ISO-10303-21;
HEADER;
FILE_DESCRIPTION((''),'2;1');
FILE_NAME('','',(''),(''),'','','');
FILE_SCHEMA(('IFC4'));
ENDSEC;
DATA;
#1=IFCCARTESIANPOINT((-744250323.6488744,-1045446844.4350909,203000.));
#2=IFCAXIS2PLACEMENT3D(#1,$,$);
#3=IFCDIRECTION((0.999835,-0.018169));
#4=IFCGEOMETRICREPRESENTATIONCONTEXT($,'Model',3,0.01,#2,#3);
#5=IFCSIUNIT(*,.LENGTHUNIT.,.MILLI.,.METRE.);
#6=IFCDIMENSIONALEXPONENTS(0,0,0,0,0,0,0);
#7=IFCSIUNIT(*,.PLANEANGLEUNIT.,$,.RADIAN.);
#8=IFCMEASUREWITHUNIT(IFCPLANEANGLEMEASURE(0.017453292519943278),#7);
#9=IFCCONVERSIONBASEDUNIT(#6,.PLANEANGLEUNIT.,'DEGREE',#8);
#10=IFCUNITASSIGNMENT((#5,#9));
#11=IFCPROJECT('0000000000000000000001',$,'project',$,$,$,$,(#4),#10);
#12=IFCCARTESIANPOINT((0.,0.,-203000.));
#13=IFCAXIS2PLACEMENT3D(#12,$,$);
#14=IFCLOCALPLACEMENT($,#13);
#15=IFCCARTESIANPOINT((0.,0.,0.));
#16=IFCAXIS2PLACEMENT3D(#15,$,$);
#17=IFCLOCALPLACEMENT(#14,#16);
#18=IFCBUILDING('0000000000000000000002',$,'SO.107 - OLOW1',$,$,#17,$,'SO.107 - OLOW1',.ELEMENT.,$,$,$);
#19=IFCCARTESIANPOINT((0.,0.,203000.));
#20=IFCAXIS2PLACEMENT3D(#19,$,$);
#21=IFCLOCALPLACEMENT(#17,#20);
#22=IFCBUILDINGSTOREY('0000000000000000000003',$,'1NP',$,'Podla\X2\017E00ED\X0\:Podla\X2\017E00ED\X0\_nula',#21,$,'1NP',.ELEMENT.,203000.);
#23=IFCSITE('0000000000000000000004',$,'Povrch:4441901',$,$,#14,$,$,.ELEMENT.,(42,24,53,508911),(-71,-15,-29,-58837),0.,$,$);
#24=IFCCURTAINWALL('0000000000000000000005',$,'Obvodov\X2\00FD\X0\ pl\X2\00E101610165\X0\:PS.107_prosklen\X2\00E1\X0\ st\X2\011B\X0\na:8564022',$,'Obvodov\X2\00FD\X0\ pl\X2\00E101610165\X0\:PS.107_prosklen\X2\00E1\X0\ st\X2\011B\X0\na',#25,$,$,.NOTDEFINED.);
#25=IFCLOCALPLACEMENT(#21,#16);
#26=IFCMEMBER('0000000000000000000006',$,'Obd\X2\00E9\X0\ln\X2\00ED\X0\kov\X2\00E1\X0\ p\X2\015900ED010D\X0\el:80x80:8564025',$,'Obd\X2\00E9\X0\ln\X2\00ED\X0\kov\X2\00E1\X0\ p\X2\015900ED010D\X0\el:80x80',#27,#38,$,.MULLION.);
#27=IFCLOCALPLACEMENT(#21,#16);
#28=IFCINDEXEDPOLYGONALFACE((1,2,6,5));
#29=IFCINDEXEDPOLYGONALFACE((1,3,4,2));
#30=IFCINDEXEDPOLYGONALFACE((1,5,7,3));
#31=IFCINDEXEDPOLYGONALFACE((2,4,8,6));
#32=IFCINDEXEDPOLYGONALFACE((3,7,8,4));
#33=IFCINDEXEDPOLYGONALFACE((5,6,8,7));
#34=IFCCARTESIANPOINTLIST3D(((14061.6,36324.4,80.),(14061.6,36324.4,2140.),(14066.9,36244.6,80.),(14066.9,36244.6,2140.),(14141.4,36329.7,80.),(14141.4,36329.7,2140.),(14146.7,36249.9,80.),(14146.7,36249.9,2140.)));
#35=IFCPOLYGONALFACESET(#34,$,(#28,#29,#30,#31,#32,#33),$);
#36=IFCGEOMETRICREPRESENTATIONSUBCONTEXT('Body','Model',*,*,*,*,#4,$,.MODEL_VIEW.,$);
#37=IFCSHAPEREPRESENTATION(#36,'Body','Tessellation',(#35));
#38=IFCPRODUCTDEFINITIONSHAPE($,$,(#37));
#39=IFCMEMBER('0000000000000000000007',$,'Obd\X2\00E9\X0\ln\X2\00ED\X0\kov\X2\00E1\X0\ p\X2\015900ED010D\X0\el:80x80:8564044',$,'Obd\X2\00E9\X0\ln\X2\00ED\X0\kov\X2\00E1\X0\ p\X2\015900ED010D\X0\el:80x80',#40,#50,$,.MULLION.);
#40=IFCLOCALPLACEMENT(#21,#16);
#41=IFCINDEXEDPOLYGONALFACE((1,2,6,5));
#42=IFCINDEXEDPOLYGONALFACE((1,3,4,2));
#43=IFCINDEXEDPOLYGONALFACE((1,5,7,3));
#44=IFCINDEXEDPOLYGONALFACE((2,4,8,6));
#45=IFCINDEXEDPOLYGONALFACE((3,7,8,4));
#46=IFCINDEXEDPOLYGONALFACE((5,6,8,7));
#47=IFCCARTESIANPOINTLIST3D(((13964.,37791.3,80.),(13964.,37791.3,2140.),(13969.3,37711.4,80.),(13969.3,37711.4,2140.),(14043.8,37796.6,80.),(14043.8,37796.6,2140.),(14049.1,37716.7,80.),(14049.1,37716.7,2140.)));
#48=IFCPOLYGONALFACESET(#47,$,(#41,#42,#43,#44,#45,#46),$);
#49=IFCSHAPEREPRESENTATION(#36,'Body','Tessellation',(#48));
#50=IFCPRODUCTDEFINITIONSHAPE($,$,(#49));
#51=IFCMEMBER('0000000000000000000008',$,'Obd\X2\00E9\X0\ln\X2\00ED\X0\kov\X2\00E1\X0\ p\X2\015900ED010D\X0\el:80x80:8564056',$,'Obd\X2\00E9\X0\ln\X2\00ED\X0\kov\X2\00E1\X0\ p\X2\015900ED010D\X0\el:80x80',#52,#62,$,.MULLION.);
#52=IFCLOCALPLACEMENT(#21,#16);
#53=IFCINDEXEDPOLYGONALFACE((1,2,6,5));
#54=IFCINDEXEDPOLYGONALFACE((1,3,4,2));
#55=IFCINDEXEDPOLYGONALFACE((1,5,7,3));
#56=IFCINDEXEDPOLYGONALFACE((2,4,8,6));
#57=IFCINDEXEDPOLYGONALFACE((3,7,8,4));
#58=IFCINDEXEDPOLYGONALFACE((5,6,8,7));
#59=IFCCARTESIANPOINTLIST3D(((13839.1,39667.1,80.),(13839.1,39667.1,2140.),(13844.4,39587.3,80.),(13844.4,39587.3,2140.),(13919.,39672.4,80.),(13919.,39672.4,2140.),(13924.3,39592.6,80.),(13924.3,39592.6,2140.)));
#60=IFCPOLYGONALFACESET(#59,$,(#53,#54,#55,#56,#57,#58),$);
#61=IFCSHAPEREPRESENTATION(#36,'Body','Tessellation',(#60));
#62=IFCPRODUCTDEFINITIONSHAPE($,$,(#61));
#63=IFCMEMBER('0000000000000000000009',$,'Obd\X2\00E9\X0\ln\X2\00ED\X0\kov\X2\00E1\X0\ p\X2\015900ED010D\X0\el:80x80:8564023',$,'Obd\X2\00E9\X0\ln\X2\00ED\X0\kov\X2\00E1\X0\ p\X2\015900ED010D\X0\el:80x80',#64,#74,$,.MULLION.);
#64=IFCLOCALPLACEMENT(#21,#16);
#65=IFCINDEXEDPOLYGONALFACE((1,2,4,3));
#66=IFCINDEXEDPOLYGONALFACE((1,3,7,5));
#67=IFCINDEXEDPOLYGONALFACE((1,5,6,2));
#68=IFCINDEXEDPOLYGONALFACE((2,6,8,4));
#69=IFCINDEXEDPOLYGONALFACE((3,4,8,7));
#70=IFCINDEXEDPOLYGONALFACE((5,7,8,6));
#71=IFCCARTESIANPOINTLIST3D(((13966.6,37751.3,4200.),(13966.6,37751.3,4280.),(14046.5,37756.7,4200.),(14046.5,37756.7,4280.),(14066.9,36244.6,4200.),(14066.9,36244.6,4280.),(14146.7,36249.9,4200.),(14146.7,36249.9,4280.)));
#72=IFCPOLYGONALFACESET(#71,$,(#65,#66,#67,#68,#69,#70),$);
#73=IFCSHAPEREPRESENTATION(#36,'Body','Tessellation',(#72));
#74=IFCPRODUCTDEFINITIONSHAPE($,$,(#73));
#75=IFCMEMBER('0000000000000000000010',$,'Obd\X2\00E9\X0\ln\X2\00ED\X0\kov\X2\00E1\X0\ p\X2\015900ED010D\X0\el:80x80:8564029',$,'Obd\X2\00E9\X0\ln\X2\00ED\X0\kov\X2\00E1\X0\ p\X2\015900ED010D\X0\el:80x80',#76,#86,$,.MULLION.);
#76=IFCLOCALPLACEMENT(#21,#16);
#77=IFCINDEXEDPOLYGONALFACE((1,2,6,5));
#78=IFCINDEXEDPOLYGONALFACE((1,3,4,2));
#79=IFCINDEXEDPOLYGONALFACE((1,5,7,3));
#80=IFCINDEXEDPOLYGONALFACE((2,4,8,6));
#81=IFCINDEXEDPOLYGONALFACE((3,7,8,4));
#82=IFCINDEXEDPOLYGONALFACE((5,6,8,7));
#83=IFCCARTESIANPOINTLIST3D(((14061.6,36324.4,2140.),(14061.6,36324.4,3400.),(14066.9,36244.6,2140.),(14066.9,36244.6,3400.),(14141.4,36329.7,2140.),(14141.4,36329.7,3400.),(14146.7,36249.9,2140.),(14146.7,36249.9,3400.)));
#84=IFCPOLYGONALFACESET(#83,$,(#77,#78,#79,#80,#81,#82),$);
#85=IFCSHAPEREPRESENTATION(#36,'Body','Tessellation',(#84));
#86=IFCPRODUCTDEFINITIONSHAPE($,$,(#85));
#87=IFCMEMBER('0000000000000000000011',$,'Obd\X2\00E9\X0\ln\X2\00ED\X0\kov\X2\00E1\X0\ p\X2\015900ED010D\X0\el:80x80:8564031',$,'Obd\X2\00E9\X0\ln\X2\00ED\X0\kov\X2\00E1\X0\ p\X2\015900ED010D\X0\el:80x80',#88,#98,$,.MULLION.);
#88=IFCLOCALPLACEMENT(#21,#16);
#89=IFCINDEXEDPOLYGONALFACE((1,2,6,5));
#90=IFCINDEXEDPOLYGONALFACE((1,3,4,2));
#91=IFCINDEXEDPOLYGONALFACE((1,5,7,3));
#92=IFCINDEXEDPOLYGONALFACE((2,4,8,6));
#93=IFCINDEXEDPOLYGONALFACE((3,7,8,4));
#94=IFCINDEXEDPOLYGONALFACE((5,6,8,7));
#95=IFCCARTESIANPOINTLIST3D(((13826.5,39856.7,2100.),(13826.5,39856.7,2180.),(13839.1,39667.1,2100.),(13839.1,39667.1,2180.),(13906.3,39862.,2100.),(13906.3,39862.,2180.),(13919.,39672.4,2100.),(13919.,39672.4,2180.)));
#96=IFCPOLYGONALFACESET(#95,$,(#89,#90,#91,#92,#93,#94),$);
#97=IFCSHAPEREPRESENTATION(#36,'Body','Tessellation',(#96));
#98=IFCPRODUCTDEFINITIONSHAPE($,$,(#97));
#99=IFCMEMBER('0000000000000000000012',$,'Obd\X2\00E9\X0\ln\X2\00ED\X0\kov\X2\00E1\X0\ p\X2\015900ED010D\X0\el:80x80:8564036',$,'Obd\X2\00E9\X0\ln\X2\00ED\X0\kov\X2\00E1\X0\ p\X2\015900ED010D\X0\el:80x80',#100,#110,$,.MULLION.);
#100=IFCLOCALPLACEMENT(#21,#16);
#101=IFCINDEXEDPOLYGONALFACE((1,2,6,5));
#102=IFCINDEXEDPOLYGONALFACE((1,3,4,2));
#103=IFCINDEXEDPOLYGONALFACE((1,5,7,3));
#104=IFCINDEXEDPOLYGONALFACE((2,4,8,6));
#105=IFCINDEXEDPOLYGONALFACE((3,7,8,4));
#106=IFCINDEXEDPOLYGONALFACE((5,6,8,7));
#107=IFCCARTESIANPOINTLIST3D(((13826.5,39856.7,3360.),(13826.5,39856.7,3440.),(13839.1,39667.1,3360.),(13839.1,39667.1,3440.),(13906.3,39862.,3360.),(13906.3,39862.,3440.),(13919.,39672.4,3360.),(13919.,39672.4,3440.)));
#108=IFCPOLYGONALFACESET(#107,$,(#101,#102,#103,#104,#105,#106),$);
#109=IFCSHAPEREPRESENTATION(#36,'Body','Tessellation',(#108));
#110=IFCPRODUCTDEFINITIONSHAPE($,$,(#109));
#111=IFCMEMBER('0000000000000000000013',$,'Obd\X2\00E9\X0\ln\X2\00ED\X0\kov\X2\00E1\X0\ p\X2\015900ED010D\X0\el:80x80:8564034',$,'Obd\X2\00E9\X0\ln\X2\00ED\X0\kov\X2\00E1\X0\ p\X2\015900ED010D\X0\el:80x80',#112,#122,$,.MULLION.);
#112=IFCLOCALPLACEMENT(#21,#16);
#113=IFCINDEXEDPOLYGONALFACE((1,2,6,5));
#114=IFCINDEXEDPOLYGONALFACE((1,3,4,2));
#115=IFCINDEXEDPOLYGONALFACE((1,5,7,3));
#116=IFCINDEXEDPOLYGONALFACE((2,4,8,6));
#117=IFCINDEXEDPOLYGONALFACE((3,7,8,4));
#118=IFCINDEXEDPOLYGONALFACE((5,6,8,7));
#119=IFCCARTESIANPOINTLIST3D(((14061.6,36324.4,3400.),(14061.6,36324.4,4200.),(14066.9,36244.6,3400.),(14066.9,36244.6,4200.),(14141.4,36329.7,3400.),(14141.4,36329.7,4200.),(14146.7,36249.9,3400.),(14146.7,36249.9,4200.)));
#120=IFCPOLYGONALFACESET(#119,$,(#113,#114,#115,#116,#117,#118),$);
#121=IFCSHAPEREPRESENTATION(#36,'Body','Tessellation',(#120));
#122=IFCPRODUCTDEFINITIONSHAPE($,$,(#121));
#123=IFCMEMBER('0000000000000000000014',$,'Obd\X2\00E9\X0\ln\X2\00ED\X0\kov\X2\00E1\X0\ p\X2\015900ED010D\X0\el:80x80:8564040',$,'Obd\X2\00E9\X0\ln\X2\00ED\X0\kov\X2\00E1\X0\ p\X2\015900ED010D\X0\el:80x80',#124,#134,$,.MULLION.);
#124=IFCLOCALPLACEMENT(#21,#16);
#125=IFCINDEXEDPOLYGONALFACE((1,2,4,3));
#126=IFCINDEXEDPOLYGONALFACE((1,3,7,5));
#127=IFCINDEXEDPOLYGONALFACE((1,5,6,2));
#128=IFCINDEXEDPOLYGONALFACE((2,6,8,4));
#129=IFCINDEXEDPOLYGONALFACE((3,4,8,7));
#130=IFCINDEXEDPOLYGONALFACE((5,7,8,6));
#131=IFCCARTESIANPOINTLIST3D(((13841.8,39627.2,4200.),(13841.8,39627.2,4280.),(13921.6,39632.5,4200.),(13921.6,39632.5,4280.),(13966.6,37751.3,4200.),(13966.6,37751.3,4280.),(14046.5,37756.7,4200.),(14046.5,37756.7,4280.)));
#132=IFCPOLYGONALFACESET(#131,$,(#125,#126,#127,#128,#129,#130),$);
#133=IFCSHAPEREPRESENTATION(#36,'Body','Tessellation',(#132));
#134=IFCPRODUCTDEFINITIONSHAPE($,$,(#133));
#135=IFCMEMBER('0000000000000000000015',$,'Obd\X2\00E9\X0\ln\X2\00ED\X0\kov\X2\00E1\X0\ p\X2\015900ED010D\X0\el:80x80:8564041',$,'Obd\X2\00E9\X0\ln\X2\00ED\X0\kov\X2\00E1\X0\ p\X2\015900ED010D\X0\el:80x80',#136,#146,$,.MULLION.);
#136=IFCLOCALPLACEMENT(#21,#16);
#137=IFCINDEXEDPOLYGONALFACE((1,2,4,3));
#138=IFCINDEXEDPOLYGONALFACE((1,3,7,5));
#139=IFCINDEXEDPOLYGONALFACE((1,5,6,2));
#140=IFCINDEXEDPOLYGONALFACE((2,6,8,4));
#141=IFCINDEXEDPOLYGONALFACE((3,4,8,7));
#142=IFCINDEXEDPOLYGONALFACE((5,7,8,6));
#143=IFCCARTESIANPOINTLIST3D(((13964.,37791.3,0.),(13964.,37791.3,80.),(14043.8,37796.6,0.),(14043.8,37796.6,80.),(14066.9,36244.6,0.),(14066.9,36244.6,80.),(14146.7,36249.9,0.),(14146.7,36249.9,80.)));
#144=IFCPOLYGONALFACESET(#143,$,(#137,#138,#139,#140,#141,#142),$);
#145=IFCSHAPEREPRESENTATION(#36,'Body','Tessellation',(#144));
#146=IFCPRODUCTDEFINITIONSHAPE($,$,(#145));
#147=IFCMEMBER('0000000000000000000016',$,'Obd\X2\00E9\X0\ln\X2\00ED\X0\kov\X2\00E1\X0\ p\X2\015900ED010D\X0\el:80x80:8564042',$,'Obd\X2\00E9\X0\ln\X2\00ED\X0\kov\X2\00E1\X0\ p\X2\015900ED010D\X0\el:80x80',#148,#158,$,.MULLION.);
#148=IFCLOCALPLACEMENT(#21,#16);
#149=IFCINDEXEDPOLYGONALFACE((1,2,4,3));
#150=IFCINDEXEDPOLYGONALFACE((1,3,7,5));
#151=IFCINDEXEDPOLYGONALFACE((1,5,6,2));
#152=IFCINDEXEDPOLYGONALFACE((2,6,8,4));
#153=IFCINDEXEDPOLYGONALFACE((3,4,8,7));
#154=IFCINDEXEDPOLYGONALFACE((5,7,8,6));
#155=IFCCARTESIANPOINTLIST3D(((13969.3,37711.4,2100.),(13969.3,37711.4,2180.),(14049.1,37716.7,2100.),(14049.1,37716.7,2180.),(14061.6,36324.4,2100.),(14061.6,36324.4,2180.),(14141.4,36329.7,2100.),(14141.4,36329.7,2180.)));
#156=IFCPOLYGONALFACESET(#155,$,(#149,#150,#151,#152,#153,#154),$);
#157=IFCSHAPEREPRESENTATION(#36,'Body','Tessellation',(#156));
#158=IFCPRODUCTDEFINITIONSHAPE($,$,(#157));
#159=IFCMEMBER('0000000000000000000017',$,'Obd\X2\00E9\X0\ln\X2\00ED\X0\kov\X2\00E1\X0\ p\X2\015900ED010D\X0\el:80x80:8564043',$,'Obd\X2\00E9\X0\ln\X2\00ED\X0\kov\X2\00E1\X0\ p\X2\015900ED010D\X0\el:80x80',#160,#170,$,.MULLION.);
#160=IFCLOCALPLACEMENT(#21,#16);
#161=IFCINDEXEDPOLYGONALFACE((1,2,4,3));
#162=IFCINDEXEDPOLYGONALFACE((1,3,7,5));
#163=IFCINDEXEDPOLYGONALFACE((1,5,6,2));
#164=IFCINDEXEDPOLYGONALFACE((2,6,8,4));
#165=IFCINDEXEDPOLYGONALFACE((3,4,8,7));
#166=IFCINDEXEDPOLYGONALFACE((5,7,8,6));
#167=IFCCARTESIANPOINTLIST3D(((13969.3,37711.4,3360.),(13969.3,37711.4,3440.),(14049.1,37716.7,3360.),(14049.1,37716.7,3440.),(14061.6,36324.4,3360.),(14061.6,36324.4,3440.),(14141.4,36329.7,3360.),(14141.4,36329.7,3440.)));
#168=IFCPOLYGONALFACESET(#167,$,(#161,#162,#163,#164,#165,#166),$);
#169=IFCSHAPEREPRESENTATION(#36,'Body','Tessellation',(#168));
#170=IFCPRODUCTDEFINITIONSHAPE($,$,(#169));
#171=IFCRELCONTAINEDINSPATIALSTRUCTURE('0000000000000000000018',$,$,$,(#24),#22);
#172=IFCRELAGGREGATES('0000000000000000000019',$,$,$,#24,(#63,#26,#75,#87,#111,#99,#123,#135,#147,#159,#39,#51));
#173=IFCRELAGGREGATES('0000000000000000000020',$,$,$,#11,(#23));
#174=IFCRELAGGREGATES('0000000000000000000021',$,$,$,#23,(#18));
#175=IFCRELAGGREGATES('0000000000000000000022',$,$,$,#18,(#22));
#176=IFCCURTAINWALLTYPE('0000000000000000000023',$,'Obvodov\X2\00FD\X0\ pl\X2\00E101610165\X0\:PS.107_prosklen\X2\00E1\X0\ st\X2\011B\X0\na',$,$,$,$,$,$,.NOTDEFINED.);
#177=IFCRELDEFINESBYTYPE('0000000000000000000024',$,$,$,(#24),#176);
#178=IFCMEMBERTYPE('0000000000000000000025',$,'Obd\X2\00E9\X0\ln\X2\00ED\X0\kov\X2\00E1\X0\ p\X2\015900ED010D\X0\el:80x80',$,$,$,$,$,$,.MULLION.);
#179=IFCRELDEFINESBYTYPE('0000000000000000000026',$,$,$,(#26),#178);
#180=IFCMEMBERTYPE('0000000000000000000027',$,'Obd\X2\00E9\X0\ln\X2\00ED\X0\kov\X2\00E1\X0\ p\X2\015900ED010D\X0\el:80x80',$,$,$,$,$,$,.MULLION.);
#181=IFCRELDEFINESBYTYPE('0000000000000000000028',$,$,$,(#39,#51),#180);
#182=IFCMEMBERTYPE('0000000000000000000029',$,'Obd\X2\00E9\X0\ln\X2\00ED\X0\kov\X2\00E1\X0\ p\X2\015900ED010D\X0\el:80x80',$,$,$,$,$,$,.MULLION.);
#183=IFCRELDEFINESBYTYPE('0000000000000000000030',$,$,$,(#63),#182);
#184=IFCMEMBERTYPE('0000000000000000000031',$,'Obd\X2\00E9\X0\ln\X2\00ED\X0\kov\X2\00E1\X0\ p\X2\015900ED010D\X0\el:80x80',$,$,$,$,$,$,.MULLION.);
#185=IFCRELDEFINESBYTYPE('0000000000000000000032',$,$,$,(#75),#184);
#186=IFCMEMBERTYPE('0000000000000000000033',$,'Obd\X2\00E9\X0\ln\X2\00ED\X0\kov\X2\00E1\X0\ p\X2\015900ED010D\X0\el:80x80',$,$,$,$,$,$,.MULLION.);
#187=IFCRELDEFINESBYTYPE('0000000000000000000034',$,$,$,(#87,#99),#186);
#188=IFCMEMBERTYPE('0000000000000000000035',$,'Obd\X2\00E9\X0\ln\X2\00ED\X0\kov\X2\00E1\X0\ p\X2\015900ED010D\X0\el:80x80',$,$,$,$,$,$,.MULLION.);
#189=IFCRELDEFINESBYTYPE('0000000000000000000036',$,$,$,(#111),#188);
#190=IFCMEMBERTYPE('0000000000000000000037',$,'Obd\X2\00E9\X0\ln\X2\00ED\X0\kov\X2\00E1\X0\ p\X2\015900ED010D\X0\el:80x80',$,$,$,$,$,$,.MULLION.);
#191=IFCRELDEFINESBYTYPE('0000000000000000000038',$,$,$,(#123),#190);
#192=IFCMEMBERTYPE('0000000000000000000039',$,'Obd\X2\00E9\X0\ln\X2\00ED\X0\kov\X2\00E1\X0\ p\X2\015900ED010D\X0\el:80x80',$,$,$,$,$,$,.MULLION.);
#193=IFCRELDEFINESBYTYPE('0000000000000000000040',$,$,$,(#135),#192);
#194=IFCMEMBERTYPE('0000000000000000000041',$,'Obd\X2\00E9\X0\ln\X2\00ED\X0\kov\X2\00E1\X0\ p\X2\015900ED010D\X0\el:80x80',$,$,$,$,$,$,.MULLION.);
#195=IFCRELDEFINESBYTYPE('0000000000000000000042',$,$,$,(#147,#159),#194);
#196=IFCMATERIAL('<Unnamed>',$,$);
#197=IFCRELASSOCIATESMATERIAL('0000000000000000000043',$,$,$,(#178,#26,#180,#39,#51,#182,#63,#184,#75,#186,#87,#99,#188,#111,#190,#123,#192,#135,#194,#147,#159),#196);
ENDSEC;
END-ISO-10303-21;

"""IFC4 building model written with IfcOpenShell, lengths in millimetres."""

from ifc_helpers import new_model, entity, si_unit, converted_unit, direction, frame, origin, place, context, subcontext, project, spatial, indexed_curve, outline, extrude, source, transform, mapped, material, type_object, type_shapes, element, aggregate, save


model = new_model("IFC4")

# Units and contexts
model_context = context("Model", 3, precision=0.01, world=frame((-744250323.6488744, -1045446844.4350909, 203000.0)), true_north=direction((0.999835, -0.018169)))
body_context = subcontext(model_context, "Body", "Model", "MODEL_VIEW")
ifc_project = project(units=[si_unit("LENGTHUNIT", "METRE", prefix="MILLI"), converted_unit("PLANEANGLEUNIT", "DEGREE", entity("IfcPlaneAngleMeasure", 0.017453292519943278), si_unit("PLANEANGLEUNIT", "RADIAN"), dimensions=[0, 0, 0, 0, 0, 0, 0])], contexts=[model_context])

# Site, building, storey
site_placement = place(None, frame((0.0, 0.0, -203000.0)))
site = spatial("IfcSite", under=ifc_project, at=site_placement, Name="Povrch:4441901", CompositionType="ELEMENT", RefLatitude=(42, 24, 53, 508911), RefLongitude=(-71, -15, -29, -58837), RefElevation=0.0)
building_placement = place(site_placement, origin())
building = spatial("IfcBuilding", under=site, at=building_placement, Name="SO.107 - OLOW1", LongName="SO.107 - OLOW1", CompositionType="ELEMENT")
storey_placement = place(building_placement, frame((0.0, 0.0, 203000.0)))
storey = spatial("IfcBuildingStorey", under=building, at=storey_placement, Name="1NP", ObjectType="Podlaží:Podlaží_nula", LongName="1NP", CompositionType="ELEMENT", Elevation=203000.0)

# Curtain wall, members
curtain_wall_type = type_object("IfcCurtainWallType", Name="Obvodový plášť:PS.107_prosklená stěna", PredefinedType="NOTDEFINED")
curtain_wall_placement = place(storey_placement, frame((0.0, 0.0, -203000.0)))
curtain_wall = element("IfcCurtainWall", 1, at=curtain_wall_placement, inside=storey, type_object=curtain_wall_type, Name="Obvodový plášť:PS.107_prosklená stěna:8564022", ObjectType="Obvodový plášť:PS.107_prosklená stěna", PredefinedType="NOTDEFINED")
ifc_material_1 = material(Name="<Unnamed>")
member_type_1 = type_object("IfcMemberType", Name="Obdélníková příčel:80x80", PredefinedType="MULLION", material=ifc_material_1)
shared_shape_1 = source(origin(), body_context, "Body", "SweptSolid", [
    extrude(outline(indexed_curve([(-40.0, -40.0), (40.0, -40.0), (40.0, 40.0), (-40.0, 40.0), (-40.0, -40.0)], self_intersect=False)), frame((-40.0, 0.0, -2060.0), z_axis=(0.0, 0.0, 1.0), x_axis=(-1.0, 0.0, 0.0)), (0.0, 0.0, 1.0), 2060.0),
])
type_shapes(member_type_1, [shared_shape_1])
member_1_placement = place(curtain_wall_placement, frame((14106.8, 36247.3, 203080.0), z_axis=(0.0, 0.0, -1.0), x_axis=(0.066409, -0.997792, 0.0)))
member_1 = element("IfcMember", 2, at=member_1_placement, type_object=member_type_1, material=ifc_material_1, Name="Obdélníková příčel:80x80:8564025", ObjectType="Obdélníková příčel:80x80", PredefinedType="MULLION", context=body_context, shape_type="MappedRepresentation", body=[
    mapped(shared_shape_1, transform((0.0, 0.0, 0.0), scale=1.0)),
])
member_type_2 = type_object("IfcMemberType", Name="Obdélníková příčel:80x80", PredefinedType="MULLION", material=ifc_material_1)
shared_shape_2 = source(origin(), body_context, "Body", "SweptSolid", [
    extrude(outline(indexed_curve([(-40.0, -40.0), (40.0, -40.0), (40.0, 40.0), (-40.0, 40.0), (-40.0, -40.0)], self_intersect=False)), frame((0.0, 0.0, -2060.0), z_axis=(0.0, 0.0, 1.0), x_axis=(-1.0, 0.0, 0.0)), (0.0, 0.0, 1.0), 2060.0),
])
type_shapes(member_type_2, [shared_shape_2])
member_2_placement = place(curtain_wall_placement, frame((14006.5, 37754.0, 203080.0), z_axis=(0.0, 0.0, -1.0), x_axis=(0.066409, -0.997792, 0.0)))
member_2 = element("IfcMember", 3, at=member_2_placement, type_object=member_type_2, material=ifc_material_1, Name="Obdélníková příčel:80x80:8564044", ObjectType="Obdélníková příčel:80x80", PredefinedType="MULLION", context=body_context, shape_type="MappedRepresentation", body=[
    mapped(shared_shape_2, transform((0.0, 0.0, 0.0), scale=1.0)),
])
member_3_placement = place(curtain_wall_placement, frame((13881.7, 39629.8, 203080.0), z_axis=(0.0, 0.0, -1.0), x_axis=(0.066409, -0.997792, 0.0)))
member_3 = element("IfcMember", 4, at=member_3_placement, type_object=member_type_2, material=ifc_material_1, Name="Obdélníková příčel:80x80:8564056", ObjectType="Obdélníková příčel:80x80", PredefinedType="MULLION", context=body_context, shape_type="MappedRepresentation", body=[
    mapped(shared_shape_2, transform((0.0, 0.0, 0.0), scale=1.0)),
])
member_type_3 = type_object("IfcMemberType", Name="Obdélníková příčel:80x80", PredefinedType="MULLION", material=ifc_material_1)
shared_shape_3 = source(origin(), body_context, "Body", "SweptSolid", [
    extrude(outline(indexed_curve([(-40.0, -40.0), (40.0, -40.0), (40.0, 40.0), (-40.0, 40.0), (-40.0, -40.0)], self_intersect=False)), frame((-40.0, 0.0, -1510.1), z_axis=(0.0, 0.0, 1.0), x_axis=(-1.0, 0.0, 0.0)), (0.0, 0.0, 1.0), 1510.1),
])
type_shapes(member_type_3, [shared_shape_3])
member_4_placement = place(curtain_wall_placement, frame((14106.8, 36247.3, 207280.0), z_axis=(0.066409, -0.997792, 0.0), x_axis=(0.0, 0.0, 1.0)))
member_4 = element("IfcMember", 5, at=member_4_placement, type_object=member_type_3, material=ifc_material_1, Name="Obdélníková příčel:80x80:8564023", ObjectType="Obdélníková příčel:80x80", PredefinedType="MULLION", context=body_context, shape_type="MappedRepresentation", body=[
    mapped(shared_shape_3, transform((0.0, 0.0, 0.0), scale=1.0)),
])
member_type_4 = type_object("IfcMemberType", Name="Obdélníková příčel:80x80", PredefinedType="MULLION", material=ifc_material_1)
shared_shape_4 = source(origin(), body_context, "Body", "SweptSolid", [
    extrude(outline(indexed_curve([(-40.0, -40.0), (40.0, -40.0), (40.0, 40.0), (-40.0, 40.0), (-40.0, -40.0)], self_intersect=False)), frame((-40.0, 0.0, -1260.0), z_axis=(0.0, 0.0, 1.0), x_axis=(-1.0, 0.0, 0.0)), (0.0, 0.0, 1.0), 1260.0),
])
type_shapes(member_type_4, [shared_shape_4])
member_5_placement = place(curtain_wall_placement, frame((14106.8, 36247.3, 205140.0), z_axis=(0.0, 0.0, -1.0), x_axis=(0.066409, -0.997792, 0.0)))
member_5 = element("IfcMember", 6, at=member_5_placement, type_object=member_type_4, material=ifc_material_1, Name="Obdélníková příčel:80x80:8564029", ObjectType="Obdélníková příčel:80x80", PredefinedType="MULLION", context=body_context, shape_type="MappedRepresentation", body=[
    mapped(shared_shape_4, transform((0.0, 0.0, 0.0), scale=1.0)),
])
member_type_5 = type_object("IfcMemberType", Name="Obdélníková příčel:80x80", PredefinedType="MULLION", material=ifc_material_1)
shared_shape_5 = source(origin(), body_context, "Body", "SweptSolid", [
    extrude(outline(indexed_curve([(-40.0, -40.0), (40.0, -40.0), (40.0, 40.0), (-40.0, 40.0), (-40.0, -40.0)], self_intersect=False)), frame((0.0, 0.0, -190.0), z_axis=(0.0, 0.0, 1.0), x_axis=(-1.0, 0.0, 0.0)), (0.0, 0.0, 1.0), 190.0),
])
type_shapes(member_type_5, [shared_shape_5])
member_6_placement = place(curtain_wall_placement, frame((13879.0, 39669.8, 205140.0), z_axis=(0.066409, -0.997792, 0.0), x_axis=(0.0, 0.0, 1.0)))
member_6 = element("IfcMember", 7, at=member_6_placement, type_object=member_type_5, material=ifc_material_1, Name="Obdélníková příčel:80x80:8564031", ObjectType="Obdélníková příčel:80x80", PredefinedType="MULLION", context=body_context, shape_type="MappedRepresentation", body=[
    mapped(shared_shape_5, transform((0.0, 0.0, 0.0), scale=1.0)),
])
member_7_placement = place(curtain_wall_placement, frame((13879.0, 39669.8, 206400.0), z_axis=(0.066409, -0.997792, 0.0), x_axis=(0.0, 0.0, 1.0)))
member_7 = element("IfcMember", 8, at=member_7_placement, type_object=member_type_5, material=ifc_material_1, Name="Obdélníková příčel:80x80:8564036", ObjectType="Obdélníková příčel:80x80", PredefinedType="MULLION", context=body_context, shape_type="MappedRepresentation", body=[
    mapped(shared_shape_5, transform((0.0, 0.0, 0.0), scale=1.0)),
])
member_type_6 = type_object("IfcMemberType", Name="Obdélníková příčel:80x80", PredefinedType="MULLION", material=ifc_material_1)
shared_shape_6 = source(origin(), body_context, "Body", "SweptSolid", [
    extrude(outline(indexed_curve([(-40.0, -40.0), (40.0, -40.0), (40.0, 40.0), (-40.0, 40.0), (-40.0, -40.0)], self_intersect=False)), frame((-40.0, 0.0, -800.0), z_axis=(0.0, 0.0, 1.0), x_axis=(-1.0, 0.0, 0.0)), (0.0, 0.0, 1.0), 800.0),
])
type_shapes(member_type_6, [shared_shape_6])
member_8_placement = place(curtain_wall_placement, frame((14106.8, 36247.3, 206400.0), z_axis=(0.0, 0.0, -1.0), x_axis=(0.066409, -0.997792, 0.0)))
member_8 = element("IfcMember", 9, at=member_8_placement, type_object=member_type_6, material=ifc_material_1, Name="Obdélníková příčel:80x80:8564034", ObjectType="Obdélníková příčel:80x80", PredefinedType="MULLION", context=body_context, shape_type="MappedRepresentation", body=[
    mapped(shared_shape_6, transform((0.0, 0.0, 0.0), scale=1.0)),
])
member_type_7 = type_object("IfcMemberType", Name="Obdélníková příčel:80x80", PredefinedType="MULLION", material=ifc_material_1)
shared_shape_7 = source(origin(), body_context, "Body", "SweptSolid", [
    extrude(outline(indexed_curve([(-40.0, -40.0), (40.0, -40.0), (40.0, 40.0), (-40.0, 40.0), (-40.0, -40.0)], self_intersect=False)), frame((-40.0, 0.0, -1880.0), z_axis=(0.0, 0.0, 1.0), x_axis=(-1.0, 0.0, 0.0)), (0.0, 0.0, 1.0), 1880.0),
])
type_shapes(member_type_7, [shared_shape_7])
member_9_placement = place(curtain_wall_placement, frame((14006.5, 37754.0, 207280.0), z_axis=(0.066409, -0.997792, 0.0), x_axis=(0.0, 0.0, 1.0)))
member_9 = element("IfcMember", 10, at=member_9_placement, type_object=member_type_7, material=ifc_material_1, Name="Obdélníková příčel:80x80:8564040", ObjectType="Obdélníková příčel:80x80", PredefinedType="MULLION", context=body_context, shape_type="MappedRepresentation", body=[
    mapped(shared_shape_7, transform((0.0, 0.0, 0.0), scale=1.0)),
])
member_type_8 = type_object("IfcMemberType", Name="Obdélníková příčel:80x80", PredefinedType="MULLION", material=ifc_material_1)
shared_shape_8 = source(origin(), body_context, "Body", "SweptSolid", [
    extrude(outline(indexed_curve([(-40.0, -40.0), (40.0, -40.0), (40.0, 40.0), (-40.0, 40.0), (-40.0, -40.0)], self_intersect=False)), frame((-40.0, 0.0, -1550.1), z_axis=(0.0, 0.0, 1.0), x_axis=(-1.0, 0.0, 0.0)), (0.0, 0.0, 1.0), 1550.1),
])
type_shapes(member_type_8, [shared_shape_8])
member_10_placement = place(curtain_wall_placement, frame((14003.9, 37793.9, 203000.0), z_axis=(-0.066409, 0.997792, 0.0), x_axis=(0.0, 0.0, -1.0)))
member_10 = element("IfcMember", 11, at=member_10_placement, type_object=member_type_8, material=ifc_material_1, Name="Obdélníková příčel:80x80:8564041", ObjectType="Obdélníková příčel:80x80", PredefinedType="MULLION", context=body_context, shape_type="MappedRepresentation", body=[
    mapped(shared_shape_8, transform((0.0, 0.0, 0.0), scale=1.0)),
])
member_type_9 = type_object("IfcMemberType", Name="Obdélníková příčel:80x80", PredefinedType="MULLION", material=ifc_material_1)
shared_shape_9 = source(origin(), body_context, "Body", "SweptSolid", [
    extrude(outline(indexed_curve([(-40.0, -40.0), (40.0, -40.0), (40.0, 40.0), (-40.0, 40.0), (-40.0, -40.0)], self_intersect=False)), frame((0.0, 0.0, -1390.1), z_axis=(0.0, 0.0, 1.0), x_axis=(-1.0, 0.0, 0.0)), (0.0, 0.0, 1.0), 1390.1),
])
type_shapes(member_type_9, [shared_shape_9])
member_11_placement = place(curtain_wall_placement, frame((14101.5, 36327.1, 205140.0), z_axis=(0.066409, -0.997792, 0.0), x_axis=(0.0, 0.0, 1.0)))
member_11 = element("IfcMember", 12, at=member_11_placement, type_object=member_type_9, material=ifc_material_1, Name="Obdélníková příčel:80x80:8564042", ObjectType="Obdélníková příčel:80x80", PredefinedType="MULLION", context=body_context, shape_type="MappedRepresentation", body=[
    mapped(shared_shape_9, transform((0.0, 0.0, 0.0), scale=1.0)),
])
member_12_placement = place(curtain_wall_placement, frame((14101.5, 36327.1, 206400.0), z_axis=(0.066409, -0.997792, 0.0), x_axis=(0.0, 0.0, 1.0)))
member_12 = element("IfcMember", 13, at=member_12_placement, type_object=member_type_9, material=ifc_material_1, Name="Obdélníková příčel:80x80:8564043", ObjectType="Obdélníková příčel:80x80", PredefinedType="MULLION", context=body_context, shape_type="MappedRepresentation", body=[
    mapped(shared_shape_9, transform((0.0, 0.0, 0.0), scale=1.0)),
])
aggregate(curtain_wall, [member_4, member_1, member_5, member_6, member_8, member_7, member_9, member_10, member_11, member_12, member_2, member_3])

save(model, "model.ifc")
